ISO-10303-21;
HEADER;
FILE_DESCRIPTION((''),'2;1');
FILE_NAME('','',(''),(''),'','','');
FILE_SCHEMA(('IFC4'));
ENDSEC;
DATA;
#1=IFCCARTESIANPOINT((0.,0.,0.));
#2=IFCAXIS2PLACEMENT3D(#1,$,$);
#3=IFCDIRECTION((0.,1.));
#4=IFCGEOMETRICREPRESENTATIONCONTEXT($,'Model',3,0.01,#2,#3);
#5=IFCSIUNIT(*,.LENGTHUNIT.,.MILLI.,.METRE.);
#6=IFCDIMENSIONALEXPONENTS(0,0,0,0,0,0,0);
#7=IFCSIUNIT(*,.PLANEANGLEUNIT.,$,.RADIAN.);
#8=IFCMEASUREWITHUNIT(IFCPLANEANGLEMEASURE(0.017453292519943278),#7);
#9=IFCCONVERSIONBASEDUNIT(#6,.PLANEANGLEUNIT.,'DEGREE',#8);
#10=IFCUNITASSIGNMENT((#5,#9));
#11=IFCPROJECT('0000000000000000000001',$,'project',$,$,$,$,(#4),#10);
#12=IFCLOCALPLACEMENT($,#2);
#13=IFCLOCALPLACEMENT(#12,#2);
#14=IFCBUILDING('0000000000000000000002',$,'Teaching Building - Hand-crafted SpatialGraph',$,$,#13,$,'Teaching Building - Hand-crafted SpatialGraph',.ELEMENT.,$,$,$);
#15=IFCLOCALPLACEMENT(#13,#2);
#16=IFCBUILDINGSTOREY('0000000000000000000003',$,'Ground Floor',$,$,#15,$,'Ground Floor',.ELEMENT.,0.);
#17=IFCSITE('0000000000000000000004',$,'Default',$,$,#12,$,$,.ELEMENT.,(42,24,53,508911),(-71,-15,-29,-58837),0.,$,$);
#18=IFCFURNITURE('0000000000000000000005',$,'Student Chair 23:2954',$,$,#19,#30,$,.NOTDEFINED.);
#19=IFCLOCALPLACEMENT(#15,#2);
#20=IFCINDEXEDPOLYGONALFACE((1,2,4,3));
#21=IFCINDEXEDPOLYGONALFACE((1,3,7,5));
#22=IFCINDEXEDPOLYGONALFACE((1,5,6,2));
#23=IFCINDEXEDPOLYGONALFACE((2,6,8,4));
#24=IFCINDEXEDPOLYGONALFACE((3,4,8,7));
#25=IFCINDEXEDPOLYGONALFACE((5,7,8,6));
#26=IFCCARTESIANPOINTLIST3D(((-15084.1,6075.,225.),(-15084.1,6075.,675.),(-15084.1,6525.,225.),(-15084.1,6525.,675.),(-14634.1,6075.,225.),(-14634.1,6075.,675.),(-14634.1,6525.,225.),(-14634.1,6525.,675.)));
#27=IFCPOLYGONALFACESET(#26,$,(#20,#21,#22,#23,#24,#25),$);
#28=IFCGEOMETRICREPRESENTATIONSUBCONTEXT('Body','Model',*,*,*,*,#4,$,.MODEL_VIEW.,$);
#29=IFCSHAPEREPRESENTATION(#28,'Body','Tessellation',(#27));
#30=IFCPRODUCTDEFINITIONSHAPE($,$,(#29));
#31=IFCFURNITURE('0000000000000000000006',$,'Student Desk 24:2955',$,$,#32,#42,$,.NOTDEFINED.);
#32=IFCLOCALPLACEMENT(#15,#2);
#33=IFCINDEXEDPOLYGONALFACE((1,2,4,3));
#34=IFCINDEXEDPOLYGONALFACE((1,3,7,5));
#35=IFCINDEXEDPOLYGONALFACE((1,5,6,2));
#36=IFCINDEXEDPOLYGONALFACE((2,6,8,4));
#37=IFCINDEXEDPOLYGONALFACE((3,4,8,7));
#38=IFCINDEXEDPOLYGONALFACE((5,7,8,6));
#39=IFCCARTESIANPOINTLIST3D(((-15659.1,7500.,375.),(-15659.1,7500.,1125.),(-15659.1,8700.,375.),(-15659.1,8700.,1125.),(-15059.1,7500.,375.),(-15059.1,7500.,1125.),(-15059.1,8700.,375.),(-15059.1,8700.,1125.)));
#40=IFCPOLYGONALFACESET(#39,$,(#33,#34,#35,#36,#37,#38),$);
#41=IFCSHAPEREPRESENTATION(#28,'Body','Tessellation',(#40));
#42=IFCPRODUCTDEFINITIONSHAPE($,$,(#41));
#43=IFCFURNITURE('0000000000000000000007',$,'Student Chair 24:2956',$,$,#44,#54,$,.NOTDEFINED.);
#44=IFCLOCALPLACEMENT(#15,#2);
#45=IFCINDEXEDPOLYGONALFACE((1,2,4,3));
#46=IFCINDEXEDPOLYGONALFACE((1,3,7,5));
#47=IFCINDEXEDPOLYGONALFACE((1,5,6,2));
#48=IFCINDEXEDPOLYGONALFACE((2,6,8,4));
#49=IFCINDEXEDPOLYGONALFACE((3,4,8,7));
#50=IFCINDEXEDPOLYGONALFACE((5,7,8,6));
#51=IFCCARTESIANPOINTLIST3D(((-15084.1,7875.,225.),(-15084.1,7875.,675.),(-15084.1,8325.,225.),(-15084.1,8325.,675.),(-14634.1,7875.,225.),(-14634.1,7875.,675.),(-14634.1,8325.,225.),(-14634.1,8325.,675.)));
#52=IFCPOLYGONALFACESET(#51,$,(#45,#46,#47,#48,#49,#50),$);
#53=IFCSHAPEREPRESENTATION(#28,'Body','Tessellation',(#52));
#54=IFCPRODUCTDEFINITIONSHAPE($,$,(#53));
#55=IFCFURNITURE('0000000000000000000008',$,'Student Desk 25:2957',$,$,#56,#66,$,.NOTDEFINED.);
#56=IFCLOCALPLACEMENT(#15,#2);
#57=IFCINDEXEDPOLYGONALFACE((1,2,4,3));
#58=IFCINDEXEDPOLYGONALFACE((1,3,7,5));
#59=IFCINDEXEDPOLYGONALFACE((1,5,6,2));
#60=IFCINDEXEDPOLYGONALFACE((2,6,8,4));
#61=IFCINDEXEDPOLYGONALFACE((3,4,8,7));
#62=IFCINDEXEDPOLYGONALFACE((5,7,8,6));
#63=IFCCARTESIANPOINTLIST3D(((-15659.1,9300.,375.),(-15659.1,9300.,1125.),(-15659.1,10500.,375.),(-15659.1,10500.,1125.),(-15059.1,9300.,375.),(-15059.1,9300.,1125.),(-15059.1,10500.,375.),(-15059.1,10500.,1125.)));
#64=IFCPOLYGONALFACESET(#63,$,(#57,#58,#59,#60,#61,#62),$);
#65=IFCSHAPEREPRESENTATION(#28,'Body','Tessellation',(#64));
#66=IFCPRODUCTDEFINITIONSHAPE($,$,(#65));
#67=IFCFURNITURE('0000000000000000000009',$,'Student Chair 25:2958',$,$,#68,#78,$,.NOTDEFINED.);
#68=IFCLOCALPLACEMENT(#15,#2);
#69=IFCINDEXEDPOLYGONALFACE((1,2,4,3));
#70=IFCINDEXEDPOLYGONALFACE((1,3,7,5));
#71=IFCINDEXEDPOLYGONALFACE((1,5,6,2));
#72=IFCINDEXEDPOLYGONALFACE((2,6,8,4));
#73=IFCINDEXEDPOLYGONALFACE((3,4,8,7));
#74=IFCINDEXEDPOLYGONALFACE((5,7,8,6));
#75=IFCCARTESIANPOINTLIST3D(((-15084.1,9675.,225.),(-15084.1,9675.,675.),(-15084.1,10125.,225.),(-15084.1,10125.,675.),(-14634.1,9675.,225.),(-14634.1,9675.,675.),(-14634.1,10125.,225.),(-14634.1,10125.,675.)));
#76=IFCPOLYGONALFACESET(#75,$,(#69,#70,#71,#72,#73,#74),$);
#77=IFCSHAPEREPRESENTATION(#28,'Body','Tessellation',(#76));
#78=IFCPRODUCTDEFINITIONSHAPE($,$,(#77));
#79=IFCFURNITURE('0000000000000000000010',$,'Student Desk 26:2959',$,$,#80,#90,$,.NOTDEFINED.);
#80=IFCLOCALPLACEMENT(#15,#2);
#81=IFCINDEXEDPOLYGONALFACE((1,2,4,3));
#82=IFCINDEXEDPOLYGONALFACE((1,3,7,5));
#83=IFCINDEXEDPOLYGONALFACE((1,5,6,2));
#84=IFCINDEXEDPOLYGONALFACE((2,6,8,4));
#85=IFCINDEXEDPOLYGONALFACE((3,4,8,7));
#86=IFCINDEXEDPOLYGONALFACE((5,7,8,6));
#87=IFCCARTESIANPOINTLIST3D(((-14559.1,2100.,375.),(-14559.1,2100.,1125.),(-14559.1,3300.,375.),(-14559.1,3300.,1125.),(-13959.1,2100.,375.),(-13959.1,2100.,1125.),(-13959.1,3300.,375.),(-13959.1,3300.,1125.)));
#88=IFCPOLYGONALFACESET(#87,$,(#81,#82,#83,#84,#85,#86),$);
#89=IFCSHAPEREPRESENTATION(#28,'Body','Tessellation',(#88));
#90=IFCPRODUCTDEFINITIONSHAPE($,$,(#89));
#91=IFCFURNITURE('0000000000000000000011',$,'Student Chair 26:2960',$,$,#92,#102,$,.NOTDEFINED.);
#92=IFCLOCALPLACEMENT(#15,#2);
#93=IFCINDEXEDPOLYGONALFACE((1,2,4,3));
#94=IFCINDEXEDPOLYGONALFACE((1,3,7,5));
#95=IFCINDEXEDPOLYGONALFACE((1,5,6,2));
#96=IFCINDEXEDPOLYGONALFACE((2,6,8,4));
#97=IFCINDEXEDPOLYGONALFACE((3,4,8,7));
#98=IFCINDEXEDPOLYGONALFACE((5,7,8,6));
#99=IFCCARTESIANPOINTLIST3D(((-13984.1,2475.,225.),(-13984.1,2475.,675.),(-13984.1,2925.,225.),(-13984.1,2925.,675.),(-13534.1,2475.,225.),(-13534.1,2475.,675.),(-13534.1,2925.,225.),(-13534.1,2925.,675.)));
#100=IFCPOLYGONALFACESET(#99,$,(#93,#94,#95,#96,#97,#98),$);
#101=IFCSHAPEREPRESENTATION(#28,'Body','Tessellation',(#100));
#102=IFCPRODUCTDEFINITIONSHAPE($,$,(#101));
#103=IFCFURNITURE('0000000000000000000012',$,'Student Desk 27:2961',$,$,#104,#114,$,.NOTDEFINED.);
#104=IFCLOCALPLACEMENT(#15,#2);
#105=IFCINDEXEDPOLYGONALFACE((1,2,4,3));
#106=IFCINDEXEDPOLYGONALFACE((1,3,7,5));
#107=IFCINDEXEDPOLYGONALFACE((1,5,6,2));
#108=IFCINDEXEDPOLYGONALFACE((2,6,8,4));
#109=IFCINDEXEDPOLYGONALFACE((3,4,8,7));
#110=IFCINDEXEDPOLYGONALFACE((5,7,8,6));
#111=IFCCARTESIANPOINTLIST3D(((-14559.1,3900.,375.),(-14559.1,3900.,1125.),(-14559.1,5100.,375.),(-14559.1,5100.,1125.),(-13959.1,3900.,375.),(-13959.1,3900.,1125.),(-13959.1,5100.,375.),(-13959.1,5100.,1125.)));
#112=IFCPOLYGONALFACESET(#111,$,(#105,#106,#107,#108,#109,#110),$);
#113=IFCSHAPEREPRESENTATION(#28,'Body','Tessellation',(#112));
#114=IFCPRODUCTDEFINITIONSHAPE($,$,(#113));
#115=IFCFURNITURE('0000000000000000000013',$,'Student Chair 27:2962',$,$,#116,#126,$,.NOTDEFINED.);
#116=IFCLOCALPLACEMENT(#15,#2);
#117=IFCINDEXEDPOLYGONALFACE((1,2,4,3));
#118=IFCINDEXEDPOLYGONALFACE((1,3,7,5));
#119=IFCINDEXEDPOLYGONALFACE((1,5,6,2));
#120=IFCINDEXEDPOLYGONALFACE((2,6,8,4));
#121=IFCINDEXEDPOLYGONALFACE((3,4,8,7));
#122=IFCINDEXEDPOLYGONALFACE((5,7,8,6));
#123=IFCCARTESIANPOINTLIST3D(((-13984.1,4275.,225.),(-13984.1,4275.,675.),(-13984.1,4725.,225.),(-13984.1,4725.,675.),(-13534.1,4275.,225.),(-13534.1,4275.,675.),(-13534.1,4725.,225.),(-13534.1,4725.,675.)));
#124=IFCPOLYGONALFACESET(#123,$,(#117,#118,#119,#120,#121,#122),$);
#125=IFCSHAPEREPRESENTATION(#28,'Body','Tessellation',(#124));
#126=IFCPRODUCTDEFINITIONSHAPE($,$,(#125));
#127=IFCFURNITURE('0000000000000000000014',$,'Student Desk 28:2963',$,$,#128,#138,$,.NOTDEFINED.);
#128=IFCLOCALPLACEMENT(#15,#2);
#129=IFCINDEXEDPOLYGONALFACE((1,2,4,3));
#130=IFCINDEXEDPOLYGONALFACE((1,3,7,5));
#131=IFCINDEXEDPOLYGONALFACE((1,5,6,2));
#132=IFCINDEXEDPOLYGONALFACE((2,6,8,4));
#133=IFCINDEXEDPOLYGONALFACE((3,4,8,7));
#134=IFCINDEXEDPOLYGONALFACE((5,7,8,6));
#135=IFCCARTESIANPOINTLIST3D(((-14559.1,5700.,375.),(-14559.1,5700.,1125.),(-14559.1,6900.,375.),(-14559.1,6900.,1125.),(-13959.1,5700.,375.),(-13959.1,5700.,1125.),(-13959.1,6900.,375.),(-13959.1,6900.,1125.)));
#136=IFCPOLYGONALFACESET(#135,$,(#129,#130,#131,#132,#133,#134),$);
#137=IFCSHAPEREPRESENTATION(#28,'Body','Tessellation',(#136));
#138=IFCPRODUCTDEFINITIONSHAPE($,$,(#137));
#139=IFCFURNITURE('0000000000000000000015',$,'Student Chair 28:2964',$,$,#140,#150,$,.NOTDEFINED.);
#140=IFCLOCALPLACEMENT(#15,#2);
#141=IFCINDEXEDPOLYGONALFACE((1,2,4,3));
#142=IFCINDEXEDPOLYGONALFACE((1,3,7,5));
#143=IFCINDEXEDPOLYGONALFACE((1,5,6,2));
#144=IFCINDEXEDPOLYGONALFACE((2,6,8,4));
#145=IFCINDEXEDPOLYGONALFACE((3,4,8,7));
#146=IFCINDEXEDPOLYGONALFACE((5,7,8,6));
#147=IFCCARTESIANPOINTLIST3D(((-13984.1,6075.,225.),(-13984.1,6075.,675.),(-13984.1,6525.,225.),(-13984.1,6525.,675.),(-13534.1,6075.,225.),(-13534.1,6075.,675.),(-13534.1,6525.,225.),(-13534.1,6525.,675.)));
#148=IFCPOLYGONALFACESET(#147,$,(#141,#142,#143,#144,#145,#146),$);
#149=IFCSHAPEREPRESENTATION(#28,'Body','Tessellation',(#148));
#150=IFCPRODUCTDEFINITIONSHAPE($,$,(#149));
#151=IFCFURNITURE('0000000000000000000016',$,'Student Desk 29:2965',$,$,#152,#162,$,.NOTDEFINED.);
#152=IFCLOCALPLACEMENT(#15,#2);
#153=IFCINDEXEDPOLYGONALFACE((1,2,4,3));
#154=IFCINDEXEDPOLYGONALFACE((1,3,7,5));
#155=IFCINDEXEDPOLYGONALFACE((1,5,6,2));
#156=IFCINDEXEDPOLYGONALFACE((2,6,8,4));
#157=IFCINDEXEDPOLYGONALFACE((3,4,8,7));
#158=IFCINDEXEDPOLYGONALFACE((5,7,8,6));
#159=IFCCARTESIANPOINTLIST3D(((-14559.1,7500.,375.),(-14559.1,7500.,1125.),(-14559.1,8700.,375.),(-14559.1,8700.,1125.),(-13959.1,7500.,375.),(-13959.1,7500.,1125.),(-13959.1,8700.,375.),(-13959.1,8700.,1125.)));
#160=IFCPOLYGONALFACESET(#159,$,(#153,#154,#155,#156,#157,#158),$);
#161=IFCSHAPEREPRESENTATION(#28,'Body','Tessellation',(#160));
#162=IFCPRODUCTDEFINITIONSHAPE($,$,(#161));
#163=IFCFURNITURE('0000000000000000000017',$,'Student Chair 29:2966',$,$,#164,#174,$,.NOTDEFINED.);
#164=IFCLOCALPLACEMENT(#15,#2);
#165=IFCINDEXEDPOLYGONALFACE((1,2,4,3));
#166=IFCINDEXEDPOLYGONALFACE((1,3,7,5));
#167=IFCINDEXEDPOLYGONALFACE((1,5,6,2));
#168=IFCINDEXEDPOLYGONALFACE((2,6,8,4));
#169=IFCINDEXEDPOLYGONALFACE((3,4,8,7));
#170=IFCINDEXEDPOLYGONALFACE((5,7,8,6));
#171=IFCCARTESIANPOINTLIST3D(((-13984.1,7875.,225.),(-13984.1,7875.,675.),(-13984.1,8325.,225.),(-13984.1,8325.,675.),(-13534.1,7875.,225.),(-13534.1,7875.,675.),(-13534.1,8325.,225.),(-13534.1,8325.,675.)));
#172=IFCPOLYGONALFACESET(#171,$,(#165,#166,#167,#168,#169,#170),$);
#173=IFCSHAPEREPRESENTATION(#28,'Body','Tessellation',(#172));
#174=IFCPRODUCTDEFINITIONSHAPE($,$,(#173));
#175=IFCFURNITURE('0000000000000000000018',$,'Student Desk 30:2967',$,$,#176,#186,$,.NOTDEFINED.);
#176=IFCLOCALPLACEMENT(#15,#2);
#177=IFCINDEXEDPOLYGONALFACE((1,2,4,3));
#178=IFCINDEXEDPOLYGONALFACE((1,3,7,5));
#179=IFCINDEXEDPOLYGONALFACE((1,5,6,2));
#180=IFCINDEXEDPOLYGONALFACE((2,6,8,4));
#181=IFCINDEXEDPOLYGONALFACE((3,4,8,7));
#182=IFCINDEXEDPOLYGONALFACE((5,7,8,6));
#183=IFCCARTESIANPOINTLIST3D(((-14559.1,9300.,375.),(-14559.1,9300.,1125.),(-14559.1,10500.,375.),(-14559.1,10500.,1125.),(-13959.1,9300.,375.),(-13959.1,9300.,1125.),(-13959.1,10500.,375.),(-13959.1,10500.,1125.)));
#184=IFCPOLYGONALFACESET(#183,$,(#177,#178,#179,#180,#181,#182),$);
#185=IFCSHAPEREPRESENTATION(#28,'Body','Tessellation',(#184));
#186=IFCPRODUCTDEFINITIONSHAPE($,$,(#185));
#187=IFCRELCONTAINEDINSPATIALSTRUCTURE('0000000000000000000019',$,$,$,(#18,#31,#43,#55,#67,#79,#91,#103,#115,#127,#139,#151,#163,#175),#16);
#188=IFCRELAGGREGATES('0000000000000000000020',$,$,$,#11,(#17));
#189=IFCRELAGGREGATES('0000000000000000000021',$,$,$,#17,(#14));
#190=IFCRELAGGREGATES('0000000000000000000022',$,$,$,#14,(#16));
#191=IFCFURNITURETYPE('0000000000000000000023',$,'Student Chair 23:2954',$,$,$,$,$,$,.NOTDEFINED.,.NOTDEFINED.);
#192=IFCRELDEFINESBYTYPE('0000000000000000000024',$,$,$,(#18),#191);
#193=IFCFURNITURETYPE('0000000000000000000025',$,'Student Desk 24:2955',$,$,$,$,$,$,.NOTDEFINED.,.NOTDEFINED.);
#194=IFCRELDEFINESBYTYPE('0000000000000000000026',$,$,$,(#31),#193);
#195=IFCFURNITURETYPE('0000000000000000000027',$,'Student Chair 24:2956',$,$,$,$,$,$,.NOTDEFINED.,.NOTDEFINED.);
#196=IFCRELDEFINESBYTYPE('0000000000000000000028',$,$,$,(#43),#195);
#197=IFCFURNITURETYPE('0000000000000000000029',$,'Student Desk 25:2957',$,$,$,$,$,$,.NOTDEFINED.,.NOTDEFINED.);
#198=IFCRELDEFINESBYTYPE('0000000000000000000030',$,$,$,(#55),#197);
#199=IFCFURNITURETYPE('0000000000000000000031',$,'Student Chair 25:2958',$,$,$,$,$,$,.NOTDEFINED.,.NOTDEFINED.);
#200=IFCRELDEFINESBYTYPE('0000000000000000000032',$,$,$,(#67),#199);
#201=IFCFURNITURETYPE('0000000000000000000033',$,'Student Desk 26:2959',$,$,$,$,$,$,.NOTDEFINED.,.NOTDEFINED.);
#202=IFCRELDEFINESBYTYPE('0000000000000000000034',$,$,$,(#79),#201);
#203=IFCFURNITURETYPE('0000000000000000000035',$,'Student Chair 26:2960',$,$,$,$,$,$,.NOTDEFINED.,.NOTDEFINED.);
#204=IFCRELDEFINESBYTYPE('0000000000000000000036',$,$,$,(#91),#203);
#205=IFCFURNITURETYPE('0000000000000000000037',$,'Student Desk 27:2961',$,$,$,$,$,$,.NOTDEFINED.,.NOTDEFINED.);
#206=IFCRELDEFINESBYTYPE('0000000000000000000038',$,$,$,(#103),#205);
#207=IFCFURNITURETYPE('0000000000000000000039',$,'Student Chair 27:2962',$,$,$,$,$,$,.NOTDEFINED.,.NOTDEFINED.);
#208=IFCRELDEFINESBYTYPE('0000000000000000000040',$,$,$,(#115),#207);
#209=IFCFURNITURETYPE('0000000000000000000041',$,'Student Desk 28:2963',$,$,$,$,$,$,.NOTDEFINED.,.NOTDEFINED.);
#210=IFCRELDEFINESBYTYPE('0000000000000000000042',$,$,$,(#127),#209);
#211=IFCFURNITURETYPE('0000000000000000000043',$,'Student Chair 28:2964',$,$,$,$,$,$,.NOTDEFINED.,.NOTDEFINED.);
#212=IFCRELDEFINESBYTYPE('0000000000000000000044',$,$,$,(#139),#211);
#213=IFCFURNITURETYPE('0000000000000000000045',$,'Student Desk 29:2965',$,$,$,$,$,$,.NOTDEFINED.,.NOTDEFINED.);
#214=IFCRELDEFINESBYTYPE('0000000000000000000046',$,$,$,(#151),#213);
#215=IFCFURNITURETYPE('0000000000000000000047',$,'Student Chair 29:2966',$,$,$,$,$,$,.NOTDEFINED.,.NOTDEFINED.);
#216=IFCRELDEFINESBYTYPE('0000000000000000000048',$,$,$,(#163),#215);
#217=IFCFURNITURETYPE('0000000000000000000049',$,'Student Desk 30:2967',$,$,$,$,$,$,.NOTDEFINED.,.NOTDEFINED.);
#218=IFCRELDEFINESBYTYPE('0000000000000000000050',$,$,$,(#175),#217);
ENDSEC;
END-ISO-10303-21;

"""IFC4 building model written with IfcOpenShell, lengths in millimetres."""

from ifc_helpers import new_model, entity, si_unit, converted_unit, direction, frame, frame_2d, origin, origin_2d_with_axis, place, context, subcontext, project, spatial, rectangle, extrude, type_object, element, save


model = new_model("IFC4")

# Units and contexts
model_context = context("Model", 3, precision=0.01, world=origin(), true_north=direction((0.0, 1.0)))
body_context = subcontext(model_context, "Body", "Model", "MODEL_VIEW")
ifc_project = project(units=[si_unit("LENGTHUNIT", "METRE", prefix="MILLI"), converted_unit("PLANEANGLEUNIT", "DEGREE", entity("IfcPlaneAngleMeasure", 0.017453292519943278), si_unit("PLANEANGLEUNIT", "RADIAN"), dimensions=[0, 0, 0, 0, 0, 0, 0])], contexts=[model_context])

# Site, building, storey
site_placement = place(None, origin())
site = spatial("IfcSite", under=ifc_project, at=site_placement, Name="Default", CompositionType="ELEMENT", RefLatitude=(42, 24, 53, 508911), RefLongitude=(-71, -15, -29, -58837), RefElevation=0.0)
building_placement = place(site_placement, origin())
building = spatial("IfcBuilding", under=site, at=building_placement, Name="Teaching Building - Hand-crafted SpatialGraph", LongName="Teaching Building - Hand-crafted SpatialGraph", CompositionType="ELEMENT")
storey_placement = place(building_placement, origin())
storey = spatial("IfcBuildingStorey", under=building, at=storey_placement, Name="Ground Floor", LongName="Ground Floor", CompositionType="ELEMENT", Elevation=0.0)

# Furniture
furniture_type_1 = type_object("IfcFurnitureType", Name="Student Chair 23:2954", PredefinedType="NOTDEFINED")
furniture_1_placement = place(storey_placement, origin())
element("IfcFurniture", 1, at=furniture_1_placement, inside=storey, type_object=furniture_type_1, Name="Student Chair 23:2954", PredefinedType="NOTDEFINED", context=body_context, shape_type="SweptSolid", body=[
    extrude(rectangle(XDim=450.0, YDim=450.0, at=origin_2d_with_axis()), frame((-14859.1, 6300.0, 225.0)), (0.0, 0.0, 1.0), 450.0),
])
furniture_type_2 = type_object("IfcFurnitureType", Name="Student Desk 24:2955", PredefinedType="NOTDEFINED")
furniture_2_placement = place(storey_placement, origin())
element("IfcFurniture", 2, at=furniture_2_placement, inside=storey, type_object=furniture_type_2, Name="Student Desk 24:2955", PredefinedType="NOTDEFINED", context=body_context, shape_type="SweptSolid", body=[
    extrude(rectangle(XDim=1200.0, YDim=600.0, at=origin_2d_with_axis()), frame((-15359.1, 8100.0, 375.0), z_axis=(0.0, 0.0, 1.0), x_axis=(0.0, 1.0, 0.0)), (0.0, 0.0, 1.0), 750.0),
])
furniture_type_3 = type_object("IfcFurnitureType", Name="Student Chair 24:2956", PredefinedType="NOTDEFINED")
furniture_3_placement = place(storey_placement, origin())
element("IfcFurniture", 3, at=furniture_3_placement, inside=storey, type_object=furniture_type_3, Name="Student Chair 24:2956", PredefinedType="NOTDEFINED", context=body_context, shape_type="SweptSolid", body=[
    extrude(rectangle(XDim=450.0, YDim=450.0, at=origin_2d_with_axis()), frame((-14859.1, 8100.0, 225.0)), (0.0, 0.0, 1.0), 450.0),
])
furniture_type_4 = type_object("IfcFurnitureType", Name="Student Desk 25:2957", PredefinedType="NOTDEFINED")
furniture_4_placement = place(storey_placement, origin())
element("IfcFurniture", 4, at=furniture_4_placement, inside=storey, type_object=furniture_type_4, Name="Student Desk 25:2957", PredefinedType="NOTDEFINED", context=body_context, shape_type="SweptSolid", body=[
    extrude(rectangle(XDim=1200.0, YDim=600.0, at=origin_2d_with_axis()), frame((-15359.1, 9900.0, 375.0), z_axis=(0.0, 0.0, 1.0), x_axis=(0.0, 1.0, 0.0)), (0.0, 0.0, 1.0), 750.0),
])
furniture_type_5 = type_object("IfcFurnitureType", Name="Student Chair 25:2958", PredefinedType="NOTDEFINED")
furniture_5_placement = place(storey_placement, origin())
element("IfcFurniture", 5, at=furniture_5_placement, inside=storey, type_object=furniture_type_5, Name="Student Chair 25:2958", PredefinedType="NOTDEFINED", context=body_context, shape_type="SweptSolid", body=[
    extrude(rectangle(XDim=450.0, YDim=450.0, at=frame_2d((0.0, 0.0), x_axis=(1.0, 0.0))), frame((-14859.1, 9900.0, 225.0)), (0.0, 0.0, 1.0), 450.0),
])
furniture_type_6 = type_object("IfcFurnitureType", Name="Student Desk 26:2959", PredefinedType="NOTDEFINED")
furniture_6_placement = place(storey_placement, origin())
element("IfcFurniture", 6, at=furniture_6_placement, inside=storey, type_object=furniture_type_6, Name="Student Desk 26:2959", PredefinedType="NOTDEFINED", context=body_context, shape_type="SweptSolid", body=[
    extrude(rectangle(XDim=1200.0, YDim=600.0, at=origin_2d_with_axis()), frame((-14259.1, 2700.0, 375.0), z_axis=(0.0, 0.0, 1.0), x_axis=(0.0, 1.0, 0.0)), (0.0, 0.0, 1.0), 750.0),
])
furniture_type_7 = type_object("IfcFurnitureType", Name="Student Chair 26:2960", PredefinedType="NOTDEFINED")
furniture_7_placement = place(storey_placement, origin())
element("IfcFurniture", 7, at=furniture_7_placement, inside=storey, type_object=furniture_type_7, Name="Student Chair 26:2960", PredefinedType="NOTDEFINED", context=body_context, shape_type="SweptSolid", body=[
    extrude(rectangle(XDim=450.0, YDim=450.0, at=origin_2d_with_axis()), frame((-13759.1, 2700.0, 225.0)), (0.0, 0.0, 1.0), 450.0),
])
furniture_type_8 = type_object("IfcFurnitureType", Name="Student Desk 27:2961", PredefinedType="NOTDEFINED")
furniture_8_placement = place(storey_placement, origin())
element("IfcFurniture", 8, at=furniture_8_placement, inside=storey, type_object=furniture_type_8, Name="Student Desk 27:2961", PredefinedType="NOTDEFINED", context=body_context, shape_type="SweptSolid", body=[
    extrude(rectangle(XDim=1200.0, YDim=600.0, at=frame_2d((0.0, 0.0), x_axis=(1.0, 0.0))), frame((-14259.1, 4500.0, 375.0), z_axis=(0.0, 0.0, 1.0), x_axis=(0.0, 1.0, 0.0)), (0.0, 0.0, 1.0), 750.0),
])
furniture_type_9 = type_object("IfcFurnitureType", Name="Student Chair 27:2962", PredefinedType="NOTDEFINED")
furniture_9_placement = place(storey_placement, origin())
element("IfcFurniture", 9, at=furniture_9_placement, inside=storey, type_object=furniture_type_9, Name="Student Chair 27:2962", PredefinedType="NOTDEFINED", context=body_context, shape_type="SweptSolid", body=[
    extrude(rectangle(XDim=450.0, YDim=450.0, at=origin_2d_with_axis()), frame((-13759.1, 4500.0, 225.0)), (0.0, 0.0, 1.0), 450.0),
])
furniture_type_10 = type_object("IfcFurnitureType", Name="Student Desk 28:2963", PredefinedType="NOTDEFINED")
furniture_10_placement = place(storey_placement, origin())
element("IfcFurniture", 10, at=furniture_10_placement, inside=storey, type_object=furniture_type_10, Name="Student Desk 28:2963", PredefinedType="NOTDEFINED", context=body_context, shape_type="SweptSolid", body=[
    extrude(rectangle(XDim=1200.0, YDim=600.0, at=origin_2d_with_axis()), frame((-14259.1, 6300.0, 375.0), z_axis=(0.0, 0.0, 1.0), x_axis=(0.0, 1.0, 0.0)), (0.0, 0.0, 1.0), 750.0),
])
furniture_type_11 = type_object("IfcFurnitureType", Name="Student Chair 28:2964", PredefinedType="NOTDEFINED")
furniture_11_placement = place(storey_placement, origin())
element("IfcFurniture", 11, at=furniture_11_placement, inside=storey, type_object=furniture_type_11, Name="Student Chair 28:2964", PredefinedType="NOTDEFINED", context=body_context, shape_type="SweptSolid", body=[
    extrude(rectangle(XDim=450.0, YDim=450.0, at=origin_2d_with_axis()), frame((-13759.1, 6300.0, 225.0)), (0.0, 0.0, 1.0), 450.0),
])
furniture_type_12 = type_object("IfcFurnitureType", Name="Student Desk 29:2965", PredefinedType="NOTDEFINED")
furniture_12_placement = place(storey_placement, origin())
element("IfcFurniture", 12, at=furniture_12_placement, inside=storey, type_object=furniture_type_12, Name="Student Desk 29:2965", PredefinedType="NOTDEFINED", context=body_context, shape_type="SweptSolid", body=[
    extrude(rectangle(XDim=1200.0, YDim=600.0, at=origin_2d_with_axis()), frame((-14259.1, 8100.0, 375.0), z_axis=(0.0, 0.0, 1.0), x_axis=(0.0, 1.0, 0.0)), (0.0, 0.0, 1.0), 750.0),
])
furniture_type_13 = type_object("IfcFurnitureType", Name="Student Chair 29:2966", PredefinedType="NOTDEFINED")
furniture_13_placement = place(storey_placement, origin())
element("IfcFurniture", 13, at=furniture_13_placement, inside=storey, type_object=furniture_type_13, Name="Student Chair 29:2966", PredefinedType="NOTDEFINED", context=body_context, shape_type="SweptSolid", body=[
    extrude(rectangle(XDim=450.0, YDim=450.0, at=origin_2d_with_axis()), frame((-13759.1, 8100.0, 225.0)), (0.0, 0.0, 1.0), 450.0),
])
furniture_type_14 = type_object("IfcFurnitureType", Name="Student Desk 30:2967", PredefinedType="NOTDEFINED")
furniture_14_placement = place(storey_placement, origin())
element("IfcFurniture", 14, at=furniture_14_placement, inside=storey, type_object=furniture_type_14, Name="Student Desk 30:2967", PredefinedType="NOTDEFINED", context=body_context, shape_type="SweptSolid", body=[
    extrude(rectangle(XDim=1200.0, YDim=600.0, at=origin_2d_with_axis()), frame((-14259.1, 9900.0, 375.0), z_axis=(0.0, 0.0, 1.0), x_axis=(0.0, 1.0, 0.0)), (0.0, 0.0, 1.0), 750.0),
])

save(model, "model.ifc")
